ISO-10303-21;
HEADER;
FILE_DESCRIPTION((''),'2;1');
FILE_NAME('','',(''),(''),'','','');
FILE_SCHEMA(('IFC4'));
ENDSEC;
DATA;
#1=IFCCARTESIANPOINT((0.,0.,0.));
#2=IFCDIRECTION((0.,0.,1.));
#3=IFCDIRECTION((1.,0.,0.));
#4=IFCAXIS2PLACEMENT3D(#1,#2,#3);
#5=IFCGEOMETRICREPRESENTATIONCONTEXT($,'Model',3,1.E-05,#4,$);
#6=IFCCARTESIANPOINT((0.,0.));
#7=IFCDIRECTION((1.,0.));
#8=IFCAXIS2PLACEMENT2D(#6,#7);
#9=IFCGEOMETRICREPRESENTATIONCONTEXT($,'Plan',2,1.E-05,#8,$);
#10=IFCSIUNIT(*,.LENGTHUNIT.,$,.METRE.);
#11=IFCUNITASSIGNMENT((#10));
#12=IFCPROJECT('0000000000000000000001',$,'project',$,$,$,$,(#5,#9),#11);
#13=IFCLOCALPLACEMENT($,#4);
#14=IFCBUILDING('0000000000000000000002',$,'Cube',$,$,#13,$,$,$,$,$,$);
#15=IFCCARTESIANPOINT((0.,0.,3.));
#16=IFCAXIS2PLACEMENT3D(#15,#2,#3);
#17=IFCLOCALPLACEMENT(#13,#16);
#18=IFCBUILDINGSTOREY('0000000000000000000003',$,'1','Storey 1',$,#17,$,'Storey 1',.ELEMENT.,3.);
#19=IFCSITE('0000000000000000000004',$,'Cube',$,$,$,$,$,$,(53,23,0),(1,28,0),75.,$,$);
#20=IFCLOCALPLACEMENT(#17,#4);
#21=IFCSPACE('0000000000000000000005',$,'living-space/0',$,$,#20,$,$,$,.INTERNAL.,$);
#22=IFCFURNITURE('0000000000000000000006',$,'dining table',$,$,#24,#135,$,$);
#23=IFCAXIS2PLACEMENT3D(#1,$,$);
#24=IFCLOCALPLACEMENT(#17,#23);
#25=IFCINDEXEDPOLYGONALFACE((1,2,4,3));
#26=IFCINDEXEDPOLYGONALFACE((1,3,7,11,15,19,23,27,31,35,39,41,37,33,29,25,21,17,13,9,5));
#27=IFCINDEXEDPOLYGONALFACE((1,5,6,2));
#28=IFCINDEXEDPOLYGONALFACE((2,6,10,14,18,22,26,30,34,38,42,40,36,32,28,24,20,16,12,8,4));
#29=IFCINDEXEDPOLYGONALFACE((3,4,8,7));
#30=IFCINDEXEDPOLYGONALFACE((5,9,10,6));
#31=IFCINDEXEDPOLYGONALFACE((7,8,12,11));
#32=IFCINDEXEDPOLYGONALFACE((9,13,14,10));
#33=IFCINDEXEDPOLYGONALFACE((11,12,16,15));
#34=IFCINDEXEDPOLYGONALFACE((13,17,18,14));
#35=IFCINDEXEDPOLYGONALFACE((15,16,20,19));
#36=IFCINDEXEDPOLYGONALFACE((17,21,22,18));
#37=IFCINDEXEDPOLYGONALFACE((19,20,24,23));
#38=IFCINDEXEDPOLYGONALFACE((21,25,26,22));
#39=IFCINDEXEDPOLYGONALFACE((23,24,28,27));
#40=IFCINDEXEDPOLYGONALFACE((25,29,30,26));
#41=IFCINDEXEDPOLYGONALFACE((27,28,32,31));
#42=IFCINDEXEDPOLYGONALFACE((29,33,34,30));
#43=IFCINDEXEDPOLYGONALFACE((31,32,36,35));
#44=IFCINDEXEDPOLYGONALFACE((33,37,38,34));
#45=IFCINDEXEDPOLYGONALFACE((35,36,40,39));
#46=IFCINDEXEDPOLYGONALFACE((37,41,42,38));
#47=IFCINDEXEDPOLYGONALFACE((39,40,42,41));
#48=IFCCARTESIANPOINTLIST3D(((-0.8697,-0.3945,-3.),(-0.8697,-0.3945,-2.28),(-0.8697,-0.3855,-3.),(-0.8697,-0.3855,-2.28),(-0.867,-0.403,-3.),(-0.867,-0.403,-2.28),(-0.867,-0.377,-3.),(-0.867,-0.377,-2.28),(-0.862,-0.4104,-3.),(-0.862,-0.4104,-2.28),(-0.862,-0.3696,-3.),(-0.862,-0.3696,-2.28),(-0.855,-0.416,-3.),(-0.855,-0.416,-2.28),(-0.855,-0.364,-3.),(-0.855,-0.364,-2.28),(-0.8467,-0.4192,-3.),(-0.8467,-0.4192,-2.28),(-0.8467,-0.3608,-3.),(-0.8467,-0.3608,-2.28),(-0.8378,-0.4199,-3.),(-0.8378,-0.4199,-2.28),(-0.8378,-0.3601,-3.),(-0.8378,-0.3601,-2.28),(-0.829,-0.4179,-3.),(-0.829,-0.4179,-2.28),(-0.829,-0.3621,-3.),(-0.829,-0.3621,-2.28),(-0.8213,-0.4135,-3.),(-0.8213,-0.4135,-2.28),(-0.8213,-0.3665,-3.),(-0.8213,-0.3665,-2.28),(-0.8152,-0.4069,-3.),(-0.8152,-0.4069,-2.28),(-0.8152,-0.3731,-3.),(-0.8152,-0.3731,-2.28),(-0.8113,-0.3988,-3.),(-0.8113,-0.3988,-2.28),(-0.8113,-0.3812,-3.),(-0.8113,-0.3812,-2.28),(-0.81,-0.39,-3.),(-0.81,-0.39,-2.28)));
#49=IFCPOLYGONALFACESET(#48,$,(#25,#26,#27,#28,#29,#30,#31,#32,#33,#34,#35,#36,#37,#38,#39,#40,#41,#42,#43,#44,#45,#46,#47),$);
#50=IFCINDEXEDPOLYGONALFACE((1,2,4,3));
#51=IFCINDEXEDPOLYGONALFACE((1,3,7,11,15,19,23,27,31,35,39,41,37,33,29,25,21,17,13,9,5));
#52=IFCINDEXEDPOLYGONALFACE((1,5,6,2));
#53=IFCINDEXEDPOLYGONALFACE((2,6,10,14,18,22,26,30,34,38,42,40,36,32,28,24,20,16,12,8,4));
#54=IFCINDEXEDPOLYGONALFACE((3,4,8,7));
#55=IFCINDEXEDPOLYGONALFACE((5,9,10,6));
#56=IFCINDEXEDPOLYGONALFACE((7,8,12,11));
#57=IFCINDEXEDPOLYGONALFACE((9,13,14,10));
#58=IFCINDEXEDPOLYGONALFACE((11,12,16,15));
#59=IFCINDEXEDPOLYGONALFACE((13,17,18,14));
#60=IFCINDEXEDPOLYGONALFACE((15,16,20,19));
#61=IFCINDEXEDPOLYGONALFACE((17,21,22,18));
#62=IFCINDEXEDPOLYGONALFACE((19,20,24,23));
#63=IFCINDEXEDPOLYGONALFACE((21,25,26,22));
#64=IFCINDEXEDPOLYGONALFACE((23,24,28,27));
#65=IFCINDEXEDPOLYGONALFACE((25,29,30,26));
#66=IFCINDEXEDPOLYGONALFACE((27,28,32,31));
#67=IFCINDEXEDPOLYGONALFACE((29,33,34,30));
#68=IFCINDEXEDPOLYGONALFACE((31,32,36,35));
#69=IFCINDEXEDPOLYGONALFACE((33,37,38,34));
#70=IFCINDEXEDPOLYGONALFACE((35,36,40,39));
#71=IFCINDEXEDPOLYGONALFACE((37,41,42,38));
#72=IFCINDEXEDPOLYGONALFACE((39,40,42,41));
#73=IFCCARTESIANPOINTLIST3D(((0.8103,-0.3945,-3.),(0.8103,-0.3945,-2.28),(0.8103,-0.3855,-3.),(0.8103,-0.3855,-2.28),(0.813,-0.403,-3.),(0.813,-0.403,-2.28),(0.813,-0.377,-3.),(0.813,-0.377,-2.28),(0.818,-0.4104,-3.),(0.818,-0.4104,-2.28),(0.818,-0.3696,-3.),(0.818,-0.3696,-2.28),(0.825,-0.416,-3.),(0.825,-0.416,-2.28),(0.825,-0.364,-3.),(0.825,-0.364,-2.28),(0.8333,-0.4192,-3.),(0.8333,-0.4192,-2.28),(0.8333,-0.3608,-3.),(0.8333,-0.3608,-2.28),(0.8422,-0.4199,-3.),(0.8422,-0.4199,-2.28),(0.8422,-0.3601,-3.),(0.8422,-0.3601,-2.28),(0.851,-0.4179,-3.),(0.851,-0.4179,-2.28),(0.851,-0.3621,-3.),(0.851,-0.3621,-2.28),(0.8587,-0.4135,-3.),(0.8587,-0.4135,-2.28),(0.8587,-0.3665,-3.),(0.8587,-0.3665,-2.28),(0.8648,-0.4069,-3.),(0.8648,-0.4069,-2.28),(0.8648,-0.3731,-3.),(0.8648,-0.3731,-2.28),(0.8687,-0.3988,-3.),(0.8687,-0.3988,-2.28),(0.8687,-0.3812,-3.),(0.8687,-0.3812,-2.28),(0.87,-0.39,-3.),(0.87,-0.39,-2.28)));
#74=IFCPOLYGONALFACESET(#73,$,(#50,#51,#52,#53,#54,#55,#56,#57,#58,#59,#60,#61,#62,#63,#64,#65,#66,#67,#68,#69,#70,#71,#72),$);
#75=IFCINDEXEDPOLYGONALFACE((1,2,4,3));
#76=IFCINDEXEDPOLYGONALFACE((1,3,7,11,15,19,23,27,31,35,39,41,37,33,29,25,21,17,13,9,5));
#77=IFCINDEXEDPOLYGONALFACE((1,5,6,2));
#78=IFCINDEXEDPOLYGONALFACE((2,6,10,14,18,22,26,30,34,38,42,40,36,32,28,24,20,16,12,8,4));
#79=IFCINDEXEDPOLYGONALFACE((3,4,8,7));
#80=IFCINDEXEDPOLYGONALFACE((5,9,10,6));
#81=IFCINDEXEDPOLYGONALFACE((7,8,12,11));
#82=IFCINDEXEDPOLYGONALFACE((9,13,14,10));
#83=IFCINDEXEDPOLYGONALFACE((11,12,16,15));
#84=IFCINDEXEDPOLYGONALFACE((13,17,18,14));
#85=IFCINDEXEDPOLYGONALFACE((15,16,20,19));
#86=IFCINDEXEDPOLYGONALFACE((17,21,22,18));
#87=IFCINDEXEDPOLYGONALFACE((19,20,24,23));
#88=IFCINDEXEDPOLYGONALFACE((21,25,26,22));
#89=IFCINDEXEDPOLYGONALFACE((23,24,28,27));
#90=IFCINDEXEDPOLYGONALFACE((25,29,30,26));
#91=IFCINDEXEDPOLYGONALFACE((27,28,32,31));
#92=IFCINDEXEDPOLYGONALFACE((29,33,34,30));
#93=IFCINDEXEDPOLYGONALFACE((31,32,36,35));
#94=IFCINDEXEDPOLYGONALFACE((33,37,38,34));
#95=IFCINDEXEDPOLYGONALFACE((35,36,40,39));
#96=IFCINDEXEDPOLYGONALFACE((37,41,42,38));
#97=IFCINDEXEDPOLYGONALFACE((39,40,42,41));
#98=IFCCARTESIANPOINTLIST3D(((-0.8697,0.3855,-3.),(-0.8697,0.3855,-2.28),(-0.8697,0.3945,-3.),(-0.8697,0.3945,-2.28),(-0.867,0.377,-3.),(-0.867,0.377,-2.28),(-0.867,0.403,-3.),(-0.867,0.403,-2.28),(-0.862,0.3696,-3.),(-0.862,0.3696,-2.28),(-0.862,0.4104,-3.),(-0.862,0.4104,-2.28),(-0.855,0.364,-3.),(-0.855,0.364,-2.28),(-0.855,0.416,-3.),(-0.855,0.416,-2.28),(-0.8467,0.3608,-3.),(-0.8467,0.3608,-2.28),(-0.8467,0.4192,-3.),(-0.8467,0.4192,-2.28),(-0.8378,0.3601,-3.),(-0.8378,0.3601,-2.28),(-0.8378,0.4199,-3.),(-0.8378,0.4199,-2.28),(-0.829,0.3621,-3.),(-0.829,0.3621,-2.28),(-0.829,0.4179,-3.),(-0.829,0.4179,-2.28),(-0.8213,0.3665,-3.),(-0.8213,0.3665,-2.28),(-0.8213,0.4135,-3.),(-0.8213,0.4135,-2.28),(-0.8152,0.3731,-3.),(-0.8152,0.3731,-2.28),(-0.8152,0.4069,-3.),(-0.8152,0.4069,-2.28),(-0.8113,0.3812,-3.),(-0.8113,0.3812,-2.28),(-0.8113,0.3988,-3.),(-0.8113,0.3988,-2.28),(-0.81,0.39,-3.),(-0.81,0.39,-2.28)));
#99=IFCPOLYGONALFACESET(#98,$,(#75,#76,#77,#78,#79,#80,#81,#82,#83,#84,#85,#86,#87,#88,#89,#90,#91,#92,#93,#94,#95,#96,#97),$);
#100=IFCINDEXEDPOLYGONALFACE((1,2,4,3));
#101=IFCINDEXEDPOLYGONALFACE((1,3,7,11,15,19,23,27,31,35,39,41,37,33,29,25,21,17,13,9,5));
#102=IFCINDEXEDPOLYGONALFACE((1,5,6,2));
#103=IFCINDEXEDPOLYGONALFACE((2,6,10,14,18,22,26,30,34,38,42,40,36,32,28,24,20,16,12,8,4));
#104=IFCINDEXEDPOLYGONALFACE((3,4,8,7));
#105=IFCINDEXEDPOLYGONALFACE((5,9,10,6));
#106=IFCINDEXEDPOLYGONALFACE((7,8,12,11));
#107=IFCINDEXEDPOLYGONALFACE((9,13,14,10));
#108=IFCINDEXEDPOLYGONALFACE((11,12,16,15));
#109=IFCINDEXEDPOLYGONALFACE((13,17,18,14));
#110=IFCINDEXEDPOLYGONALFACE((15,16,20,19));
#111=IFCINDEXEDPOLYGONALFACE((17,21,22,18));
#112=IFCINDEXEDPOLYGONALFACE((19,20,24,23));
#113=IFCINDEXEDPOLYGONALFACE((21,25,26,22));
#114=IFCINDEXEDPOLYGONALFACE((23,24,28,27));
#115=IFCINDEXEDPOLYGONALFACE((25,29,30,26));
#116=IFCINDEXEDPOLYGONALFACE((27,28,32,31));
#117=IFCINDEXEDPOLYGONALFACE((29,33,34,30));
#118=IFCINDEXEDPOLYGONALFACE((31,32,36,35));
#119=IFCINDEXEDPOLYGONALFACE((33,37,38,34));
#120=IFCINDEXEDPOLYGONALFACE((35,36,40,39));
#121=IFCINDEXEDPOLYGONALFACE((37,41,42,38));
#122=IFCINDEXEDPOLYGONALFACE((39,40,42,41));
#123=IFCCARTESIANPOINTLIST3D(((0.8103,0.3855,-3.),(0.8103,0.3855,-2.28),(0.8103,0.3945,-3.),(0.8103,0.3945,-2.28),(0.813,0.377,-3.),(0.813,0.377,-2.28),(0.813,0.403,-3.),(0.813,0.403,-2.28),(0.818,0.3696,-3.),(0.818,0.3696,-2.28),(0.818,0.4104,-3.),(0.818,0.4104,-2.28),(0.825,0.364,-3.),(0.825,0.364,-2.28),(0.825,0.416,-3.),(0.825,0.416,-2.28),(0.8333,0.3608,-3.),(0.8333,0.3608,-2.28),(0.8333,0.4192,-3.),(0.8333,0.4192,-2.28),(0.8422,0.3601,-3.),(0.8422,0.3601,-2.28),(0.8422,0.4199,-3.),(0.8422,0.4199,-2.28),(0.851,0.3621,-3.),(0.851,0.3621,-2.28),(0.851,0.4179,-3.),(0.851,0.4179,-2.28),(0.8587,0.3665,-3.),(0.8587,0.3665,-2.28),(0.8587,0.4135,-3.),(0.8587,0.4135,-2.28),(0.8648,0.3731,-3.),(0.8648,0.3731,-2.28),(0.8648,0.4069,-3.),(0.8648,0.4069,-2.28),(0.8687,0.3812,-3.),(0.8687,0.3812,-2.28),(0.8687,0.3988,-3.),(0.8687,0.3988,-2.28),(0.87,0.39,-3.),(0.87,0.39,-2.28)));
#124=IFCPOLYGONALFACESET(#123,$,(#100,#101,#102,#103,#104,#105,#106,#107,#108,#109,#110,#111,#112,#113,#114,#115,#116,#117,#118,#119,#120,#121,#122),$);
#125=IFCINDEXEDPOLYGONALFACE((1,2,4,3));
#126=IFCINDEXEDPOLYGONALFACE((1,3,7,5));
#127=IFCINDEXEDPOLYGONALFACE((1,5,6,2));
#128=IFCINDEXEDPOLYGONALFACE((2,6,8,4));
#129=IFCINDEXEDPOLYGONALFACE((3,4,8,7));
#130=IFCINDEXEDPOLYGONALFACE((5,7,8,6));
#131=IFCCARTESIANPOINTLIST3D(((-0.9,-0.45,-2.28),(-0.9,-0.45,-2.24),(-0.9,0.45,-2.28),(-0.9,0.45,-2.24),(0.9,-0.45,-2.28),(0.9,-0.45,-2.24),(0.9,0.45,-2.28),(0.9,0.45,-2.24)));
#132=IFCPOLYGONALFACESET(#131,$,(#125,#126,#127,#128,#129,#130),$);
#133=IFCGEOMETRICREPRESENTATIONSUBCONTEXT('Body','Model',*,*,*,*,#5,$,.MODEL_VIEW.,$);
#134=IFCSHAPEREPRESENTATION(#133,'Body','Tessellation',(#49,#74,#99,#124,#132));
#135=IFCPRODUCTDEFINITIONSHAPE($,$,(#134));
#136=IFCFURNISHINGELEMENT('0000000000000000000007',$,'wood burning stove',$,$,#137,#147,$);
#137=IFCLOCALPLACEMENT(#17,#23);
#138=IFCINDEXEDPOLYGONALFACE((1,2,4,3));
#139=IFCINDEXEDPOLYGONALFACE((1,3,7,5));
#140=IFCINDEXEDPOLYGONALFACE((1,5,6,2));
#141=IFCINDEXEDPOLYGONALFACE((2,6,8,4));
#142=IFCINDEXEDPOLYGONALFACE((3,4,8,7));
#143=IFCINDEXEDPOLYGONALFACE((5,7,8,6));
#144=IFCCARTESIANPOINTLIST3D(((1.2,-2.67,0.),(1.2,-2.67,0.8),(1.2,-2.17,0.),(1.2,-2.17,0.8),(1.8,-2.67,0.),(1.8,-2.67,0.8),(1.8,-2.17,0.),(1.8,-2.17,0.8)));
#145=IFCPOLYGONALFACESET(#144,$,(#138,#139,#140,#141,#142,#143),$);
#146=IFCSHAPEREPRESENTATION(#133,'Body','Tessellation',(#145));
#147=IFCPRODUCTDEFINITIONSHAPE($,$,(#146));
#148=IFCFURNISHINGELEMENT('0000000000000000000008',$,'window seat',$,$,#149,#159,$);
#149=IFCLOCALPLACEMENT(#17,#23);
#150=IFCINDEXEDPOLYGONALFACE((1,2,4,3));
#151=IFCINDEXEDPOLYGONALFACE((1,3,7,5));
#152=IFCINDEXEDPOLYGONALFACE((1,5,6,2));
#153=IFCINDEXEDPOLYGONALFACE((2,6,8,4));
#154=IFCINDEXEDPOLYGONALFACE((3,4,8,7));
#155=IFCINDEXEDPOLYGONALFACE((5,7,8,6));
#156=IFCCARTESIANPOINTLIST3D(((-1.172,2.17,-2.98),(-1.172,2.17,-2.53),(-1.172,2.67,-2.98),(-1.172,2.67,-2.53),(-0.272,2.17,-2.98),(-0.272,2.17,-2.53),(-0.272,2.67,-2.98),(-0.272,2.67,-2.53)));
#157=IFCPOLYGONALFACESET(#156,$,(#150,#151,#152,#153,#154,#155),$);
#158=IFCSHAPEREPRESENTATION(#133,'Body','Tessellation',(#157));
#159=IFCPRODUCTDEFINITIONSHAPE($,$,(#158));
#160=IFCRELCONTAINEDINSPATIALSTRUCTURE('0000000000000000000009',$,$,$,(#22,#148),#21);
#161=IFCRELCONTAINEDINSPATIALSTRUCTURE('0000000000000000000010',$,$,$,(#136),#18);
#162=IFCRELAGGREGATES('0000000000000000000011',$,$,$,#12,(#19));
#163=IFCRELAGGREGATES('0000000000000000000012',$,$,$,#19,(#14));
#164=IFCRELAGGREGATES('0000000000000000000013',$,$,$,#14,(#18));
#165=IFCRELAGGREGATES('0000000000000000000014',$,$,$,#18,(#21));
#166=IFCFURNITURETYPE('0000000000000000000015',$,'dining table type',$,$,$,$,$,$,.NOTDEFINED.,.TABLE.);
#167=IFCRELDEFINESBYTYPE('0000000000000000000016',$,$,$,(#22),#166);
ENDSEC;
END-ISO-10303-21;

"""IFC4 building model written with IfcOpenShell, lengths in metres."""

from ifc_helpers import new_model, entity, si_unit, frame, origin_with_axes, origin_2d_with_axis, place, context, subcontext, project, spatial, line, indexed_curve, outline, extrude, source, transform, mapped, type_object, type_shapes, element, save


model = new_model("IFC4")

# Units and contexts
model_context = context("Model", 3, precision=1e-05, world=origin_with_axes())
plan_context = context("Plan", 2, precision=1e-05, world=origin_2d_with_axis())
body_context_1 = subcontext(model_context, "Body", "Model", "MODEL_VIEW")
ifc_project = project(units=[si_unit("LENGTHUNIT", "METRE")], contexts=[model_context, plan_context])

# Site, building, storey
site = spatial("IfcSite", under=ifc_project, Name="Cube", RefLatitude=(53, 23, 0), RefLongitude=(1, 28, 0), RefElevation=75.0)
building_placement = place(None, origin_with_axes())
building = spatial("IfcBuilding", under=site, at=building_placement, Name="Cube")
storey_placement = place(building_placement, frame((0.0, 0.0, 3.0), z_axis=(0.0, 0.0, 1.0), x_axis=(1.0, 0.0, 0.0)))
storey = spatial("IfcBuildingStorey", under=building, at=storey_placement, Name="1", Description="Storey 1", LongName="Storey 1", CompositionType="ELEMENT", Elevation=3.0)

# Shared definitions
space_placement = place(storey_placement, origin_with_axes())
space = spatial("IfcSpace", under=storey, at=space_placement, Name="living-space/0", PredefinedType="INTERNAL")

# Furniture
furniture_type_1 = type_object("IfcFurnitureType", Name="dining table type", AssemblyPlace="NOTDEFINED", PredefinedType="TABLE")
shared_circle = entity("IfcCircle", entity("IfcAxis2Placement2D", entity("IfcCartesianPoint", [0.0, 0.0])), 0.03)
shared_shape_1 = source(origin_with_axes(), body_context_1, "Body", "SweptSolid", [
    entity("IfcExtrudedAreaSolid", entity("IfcArbitraryClosedProfileDef", "AREA", None, shared_circle), entity("IfcAxis2Placement3D", entity("IfcCartesianPoint", [-0.84, -0.39, 0.0]), entity("IfcDirection", [0.0, 0.0, 1.0]), entity("IfcDirection", [1.0, 0.0, 0.0])), entity("IfcDirection", [0.0, 0.0, 1.0]), 0.72),
    entity("IfcExtrudedAreaSolid", entity("IfcArbitraryClosedProfileDef", "AREA", None, shared_circle), entity("IfcAxis2Placement3D", entity("IfcCartesianPoint", [0.84, -0.39, 0.0]), entity("IfcDirection", [0.0, 0.0, 1.0]), entity("IfcDirection", [1.0, 0.0, 0.0])), entity("IfcDirection", [0.0, 0.0, 1.0]), 0.72),
    entity("IfcExtrudedAreaSolid", entity("IfcArbitraryClosedProfileDef", "AREA", None, shared_circle), entity("IfcAxis2Placement3D", entity("IfcCartesianPoint", [-0.84, 0.39, 0.0]), entity("IfcDirection", [0.0, 0.0, 1.0]), entity("IfcDirection", [1.0, 0.0, 0.0])), entity("IfcDirection", [0.0, 0.0, 1.0]), 0.72),
    entity("IfcExtrudedAreaSolid", entity("IfcArbitraryClosedProfileDef", "AREA", None, shared_circle), entity("IfcAxis2Placement3D", entity("IfcCartesianPoint", [0.84, 0.39, 0.0]), entity("IfcDirection", [0.0, 0.0, 1.0]), entity("IfcDirection", [1.0, 0.0, 0.0])), entity("IfcDirection", [0.0, 0.0, 1.0]), 0.72),
    extrude(outline(indexed_curve([(-0.9, -0.45), (0.9, -0.45), (0.9, 0.45), (-0.9, 0.45)], segments=[line(1, 2, 3, 4, 1)])), frame((0.0, 0.0, 0.72), z_axis=(0.0, 0.0, 1.0), x_axis=(1.0, 0.0, 0.0)), (0.0, 0.0, 1.0), 0.04),
])
type_shapes(furniture_type_1, [shared_shape_1])
furniture_placement = place(space_placement, frame((0.0, 0.0, -3.0), z_axis=(0.0, 0.0, 1.0), x_axis=(1.0, 0.0, 0.0)))
element("IfcFurniture", 1, at=furniture_placement, inside=space, type_object=furniture_type_1, Name="dining table", context=body_context_1, shape_type="MappedRepresentation", body=[
    mapped(shared_shape_1, transform((0.0, 0.0, 0.0), x_axis=(1.0, 0.0, 0.0), y_axis=(0.0, 1.0, 0.0), z_axis=(0.0, 0.0, 1.0), scale=1.0)),
])

# Furnishing elements
furnishing_1_placement = place(storey_placement, frame((1.2, -2.67, 0.0), z_axis=(0.0, 0.0, 1.0), x_axis=(1.0, 0.0, 0.0)))
element("IfcFurnishingElement", 2, at=furnishing_1_placement, inside=storey, Name="wood burning stove", context=body_context_1, shape_type="SweptSolid", body=[
    extrude(outline(indexed_curve([(0.0, 0.0), (0.6, 0.0), (0.6, 0.5), (0.0, 0.5)])), None, (0.0, 0.0, 1.0), 0.8),
])
furnishing_2_placement = place(space_placement, frame((-1.172, 2.17, -2.98), z_axis=(0.0, 0.0, 1.0), x_axis=(1.0, 0.0, 0.0)))
element("IfcFurnishingElement", 3, at=furnishing_2_placement, inside=space, Name="window seat", context=body_context_1, shape_type="SweptSolid", body=[
    extrude(outline(indexed_curve([(0.0, 0.0), (0.9, 0.0), (0.9, 0.5), (0.0, 0.5)])), None, (0.0, 0.0, 1.0), 0.45),
])

save(model, "model.ifc")
